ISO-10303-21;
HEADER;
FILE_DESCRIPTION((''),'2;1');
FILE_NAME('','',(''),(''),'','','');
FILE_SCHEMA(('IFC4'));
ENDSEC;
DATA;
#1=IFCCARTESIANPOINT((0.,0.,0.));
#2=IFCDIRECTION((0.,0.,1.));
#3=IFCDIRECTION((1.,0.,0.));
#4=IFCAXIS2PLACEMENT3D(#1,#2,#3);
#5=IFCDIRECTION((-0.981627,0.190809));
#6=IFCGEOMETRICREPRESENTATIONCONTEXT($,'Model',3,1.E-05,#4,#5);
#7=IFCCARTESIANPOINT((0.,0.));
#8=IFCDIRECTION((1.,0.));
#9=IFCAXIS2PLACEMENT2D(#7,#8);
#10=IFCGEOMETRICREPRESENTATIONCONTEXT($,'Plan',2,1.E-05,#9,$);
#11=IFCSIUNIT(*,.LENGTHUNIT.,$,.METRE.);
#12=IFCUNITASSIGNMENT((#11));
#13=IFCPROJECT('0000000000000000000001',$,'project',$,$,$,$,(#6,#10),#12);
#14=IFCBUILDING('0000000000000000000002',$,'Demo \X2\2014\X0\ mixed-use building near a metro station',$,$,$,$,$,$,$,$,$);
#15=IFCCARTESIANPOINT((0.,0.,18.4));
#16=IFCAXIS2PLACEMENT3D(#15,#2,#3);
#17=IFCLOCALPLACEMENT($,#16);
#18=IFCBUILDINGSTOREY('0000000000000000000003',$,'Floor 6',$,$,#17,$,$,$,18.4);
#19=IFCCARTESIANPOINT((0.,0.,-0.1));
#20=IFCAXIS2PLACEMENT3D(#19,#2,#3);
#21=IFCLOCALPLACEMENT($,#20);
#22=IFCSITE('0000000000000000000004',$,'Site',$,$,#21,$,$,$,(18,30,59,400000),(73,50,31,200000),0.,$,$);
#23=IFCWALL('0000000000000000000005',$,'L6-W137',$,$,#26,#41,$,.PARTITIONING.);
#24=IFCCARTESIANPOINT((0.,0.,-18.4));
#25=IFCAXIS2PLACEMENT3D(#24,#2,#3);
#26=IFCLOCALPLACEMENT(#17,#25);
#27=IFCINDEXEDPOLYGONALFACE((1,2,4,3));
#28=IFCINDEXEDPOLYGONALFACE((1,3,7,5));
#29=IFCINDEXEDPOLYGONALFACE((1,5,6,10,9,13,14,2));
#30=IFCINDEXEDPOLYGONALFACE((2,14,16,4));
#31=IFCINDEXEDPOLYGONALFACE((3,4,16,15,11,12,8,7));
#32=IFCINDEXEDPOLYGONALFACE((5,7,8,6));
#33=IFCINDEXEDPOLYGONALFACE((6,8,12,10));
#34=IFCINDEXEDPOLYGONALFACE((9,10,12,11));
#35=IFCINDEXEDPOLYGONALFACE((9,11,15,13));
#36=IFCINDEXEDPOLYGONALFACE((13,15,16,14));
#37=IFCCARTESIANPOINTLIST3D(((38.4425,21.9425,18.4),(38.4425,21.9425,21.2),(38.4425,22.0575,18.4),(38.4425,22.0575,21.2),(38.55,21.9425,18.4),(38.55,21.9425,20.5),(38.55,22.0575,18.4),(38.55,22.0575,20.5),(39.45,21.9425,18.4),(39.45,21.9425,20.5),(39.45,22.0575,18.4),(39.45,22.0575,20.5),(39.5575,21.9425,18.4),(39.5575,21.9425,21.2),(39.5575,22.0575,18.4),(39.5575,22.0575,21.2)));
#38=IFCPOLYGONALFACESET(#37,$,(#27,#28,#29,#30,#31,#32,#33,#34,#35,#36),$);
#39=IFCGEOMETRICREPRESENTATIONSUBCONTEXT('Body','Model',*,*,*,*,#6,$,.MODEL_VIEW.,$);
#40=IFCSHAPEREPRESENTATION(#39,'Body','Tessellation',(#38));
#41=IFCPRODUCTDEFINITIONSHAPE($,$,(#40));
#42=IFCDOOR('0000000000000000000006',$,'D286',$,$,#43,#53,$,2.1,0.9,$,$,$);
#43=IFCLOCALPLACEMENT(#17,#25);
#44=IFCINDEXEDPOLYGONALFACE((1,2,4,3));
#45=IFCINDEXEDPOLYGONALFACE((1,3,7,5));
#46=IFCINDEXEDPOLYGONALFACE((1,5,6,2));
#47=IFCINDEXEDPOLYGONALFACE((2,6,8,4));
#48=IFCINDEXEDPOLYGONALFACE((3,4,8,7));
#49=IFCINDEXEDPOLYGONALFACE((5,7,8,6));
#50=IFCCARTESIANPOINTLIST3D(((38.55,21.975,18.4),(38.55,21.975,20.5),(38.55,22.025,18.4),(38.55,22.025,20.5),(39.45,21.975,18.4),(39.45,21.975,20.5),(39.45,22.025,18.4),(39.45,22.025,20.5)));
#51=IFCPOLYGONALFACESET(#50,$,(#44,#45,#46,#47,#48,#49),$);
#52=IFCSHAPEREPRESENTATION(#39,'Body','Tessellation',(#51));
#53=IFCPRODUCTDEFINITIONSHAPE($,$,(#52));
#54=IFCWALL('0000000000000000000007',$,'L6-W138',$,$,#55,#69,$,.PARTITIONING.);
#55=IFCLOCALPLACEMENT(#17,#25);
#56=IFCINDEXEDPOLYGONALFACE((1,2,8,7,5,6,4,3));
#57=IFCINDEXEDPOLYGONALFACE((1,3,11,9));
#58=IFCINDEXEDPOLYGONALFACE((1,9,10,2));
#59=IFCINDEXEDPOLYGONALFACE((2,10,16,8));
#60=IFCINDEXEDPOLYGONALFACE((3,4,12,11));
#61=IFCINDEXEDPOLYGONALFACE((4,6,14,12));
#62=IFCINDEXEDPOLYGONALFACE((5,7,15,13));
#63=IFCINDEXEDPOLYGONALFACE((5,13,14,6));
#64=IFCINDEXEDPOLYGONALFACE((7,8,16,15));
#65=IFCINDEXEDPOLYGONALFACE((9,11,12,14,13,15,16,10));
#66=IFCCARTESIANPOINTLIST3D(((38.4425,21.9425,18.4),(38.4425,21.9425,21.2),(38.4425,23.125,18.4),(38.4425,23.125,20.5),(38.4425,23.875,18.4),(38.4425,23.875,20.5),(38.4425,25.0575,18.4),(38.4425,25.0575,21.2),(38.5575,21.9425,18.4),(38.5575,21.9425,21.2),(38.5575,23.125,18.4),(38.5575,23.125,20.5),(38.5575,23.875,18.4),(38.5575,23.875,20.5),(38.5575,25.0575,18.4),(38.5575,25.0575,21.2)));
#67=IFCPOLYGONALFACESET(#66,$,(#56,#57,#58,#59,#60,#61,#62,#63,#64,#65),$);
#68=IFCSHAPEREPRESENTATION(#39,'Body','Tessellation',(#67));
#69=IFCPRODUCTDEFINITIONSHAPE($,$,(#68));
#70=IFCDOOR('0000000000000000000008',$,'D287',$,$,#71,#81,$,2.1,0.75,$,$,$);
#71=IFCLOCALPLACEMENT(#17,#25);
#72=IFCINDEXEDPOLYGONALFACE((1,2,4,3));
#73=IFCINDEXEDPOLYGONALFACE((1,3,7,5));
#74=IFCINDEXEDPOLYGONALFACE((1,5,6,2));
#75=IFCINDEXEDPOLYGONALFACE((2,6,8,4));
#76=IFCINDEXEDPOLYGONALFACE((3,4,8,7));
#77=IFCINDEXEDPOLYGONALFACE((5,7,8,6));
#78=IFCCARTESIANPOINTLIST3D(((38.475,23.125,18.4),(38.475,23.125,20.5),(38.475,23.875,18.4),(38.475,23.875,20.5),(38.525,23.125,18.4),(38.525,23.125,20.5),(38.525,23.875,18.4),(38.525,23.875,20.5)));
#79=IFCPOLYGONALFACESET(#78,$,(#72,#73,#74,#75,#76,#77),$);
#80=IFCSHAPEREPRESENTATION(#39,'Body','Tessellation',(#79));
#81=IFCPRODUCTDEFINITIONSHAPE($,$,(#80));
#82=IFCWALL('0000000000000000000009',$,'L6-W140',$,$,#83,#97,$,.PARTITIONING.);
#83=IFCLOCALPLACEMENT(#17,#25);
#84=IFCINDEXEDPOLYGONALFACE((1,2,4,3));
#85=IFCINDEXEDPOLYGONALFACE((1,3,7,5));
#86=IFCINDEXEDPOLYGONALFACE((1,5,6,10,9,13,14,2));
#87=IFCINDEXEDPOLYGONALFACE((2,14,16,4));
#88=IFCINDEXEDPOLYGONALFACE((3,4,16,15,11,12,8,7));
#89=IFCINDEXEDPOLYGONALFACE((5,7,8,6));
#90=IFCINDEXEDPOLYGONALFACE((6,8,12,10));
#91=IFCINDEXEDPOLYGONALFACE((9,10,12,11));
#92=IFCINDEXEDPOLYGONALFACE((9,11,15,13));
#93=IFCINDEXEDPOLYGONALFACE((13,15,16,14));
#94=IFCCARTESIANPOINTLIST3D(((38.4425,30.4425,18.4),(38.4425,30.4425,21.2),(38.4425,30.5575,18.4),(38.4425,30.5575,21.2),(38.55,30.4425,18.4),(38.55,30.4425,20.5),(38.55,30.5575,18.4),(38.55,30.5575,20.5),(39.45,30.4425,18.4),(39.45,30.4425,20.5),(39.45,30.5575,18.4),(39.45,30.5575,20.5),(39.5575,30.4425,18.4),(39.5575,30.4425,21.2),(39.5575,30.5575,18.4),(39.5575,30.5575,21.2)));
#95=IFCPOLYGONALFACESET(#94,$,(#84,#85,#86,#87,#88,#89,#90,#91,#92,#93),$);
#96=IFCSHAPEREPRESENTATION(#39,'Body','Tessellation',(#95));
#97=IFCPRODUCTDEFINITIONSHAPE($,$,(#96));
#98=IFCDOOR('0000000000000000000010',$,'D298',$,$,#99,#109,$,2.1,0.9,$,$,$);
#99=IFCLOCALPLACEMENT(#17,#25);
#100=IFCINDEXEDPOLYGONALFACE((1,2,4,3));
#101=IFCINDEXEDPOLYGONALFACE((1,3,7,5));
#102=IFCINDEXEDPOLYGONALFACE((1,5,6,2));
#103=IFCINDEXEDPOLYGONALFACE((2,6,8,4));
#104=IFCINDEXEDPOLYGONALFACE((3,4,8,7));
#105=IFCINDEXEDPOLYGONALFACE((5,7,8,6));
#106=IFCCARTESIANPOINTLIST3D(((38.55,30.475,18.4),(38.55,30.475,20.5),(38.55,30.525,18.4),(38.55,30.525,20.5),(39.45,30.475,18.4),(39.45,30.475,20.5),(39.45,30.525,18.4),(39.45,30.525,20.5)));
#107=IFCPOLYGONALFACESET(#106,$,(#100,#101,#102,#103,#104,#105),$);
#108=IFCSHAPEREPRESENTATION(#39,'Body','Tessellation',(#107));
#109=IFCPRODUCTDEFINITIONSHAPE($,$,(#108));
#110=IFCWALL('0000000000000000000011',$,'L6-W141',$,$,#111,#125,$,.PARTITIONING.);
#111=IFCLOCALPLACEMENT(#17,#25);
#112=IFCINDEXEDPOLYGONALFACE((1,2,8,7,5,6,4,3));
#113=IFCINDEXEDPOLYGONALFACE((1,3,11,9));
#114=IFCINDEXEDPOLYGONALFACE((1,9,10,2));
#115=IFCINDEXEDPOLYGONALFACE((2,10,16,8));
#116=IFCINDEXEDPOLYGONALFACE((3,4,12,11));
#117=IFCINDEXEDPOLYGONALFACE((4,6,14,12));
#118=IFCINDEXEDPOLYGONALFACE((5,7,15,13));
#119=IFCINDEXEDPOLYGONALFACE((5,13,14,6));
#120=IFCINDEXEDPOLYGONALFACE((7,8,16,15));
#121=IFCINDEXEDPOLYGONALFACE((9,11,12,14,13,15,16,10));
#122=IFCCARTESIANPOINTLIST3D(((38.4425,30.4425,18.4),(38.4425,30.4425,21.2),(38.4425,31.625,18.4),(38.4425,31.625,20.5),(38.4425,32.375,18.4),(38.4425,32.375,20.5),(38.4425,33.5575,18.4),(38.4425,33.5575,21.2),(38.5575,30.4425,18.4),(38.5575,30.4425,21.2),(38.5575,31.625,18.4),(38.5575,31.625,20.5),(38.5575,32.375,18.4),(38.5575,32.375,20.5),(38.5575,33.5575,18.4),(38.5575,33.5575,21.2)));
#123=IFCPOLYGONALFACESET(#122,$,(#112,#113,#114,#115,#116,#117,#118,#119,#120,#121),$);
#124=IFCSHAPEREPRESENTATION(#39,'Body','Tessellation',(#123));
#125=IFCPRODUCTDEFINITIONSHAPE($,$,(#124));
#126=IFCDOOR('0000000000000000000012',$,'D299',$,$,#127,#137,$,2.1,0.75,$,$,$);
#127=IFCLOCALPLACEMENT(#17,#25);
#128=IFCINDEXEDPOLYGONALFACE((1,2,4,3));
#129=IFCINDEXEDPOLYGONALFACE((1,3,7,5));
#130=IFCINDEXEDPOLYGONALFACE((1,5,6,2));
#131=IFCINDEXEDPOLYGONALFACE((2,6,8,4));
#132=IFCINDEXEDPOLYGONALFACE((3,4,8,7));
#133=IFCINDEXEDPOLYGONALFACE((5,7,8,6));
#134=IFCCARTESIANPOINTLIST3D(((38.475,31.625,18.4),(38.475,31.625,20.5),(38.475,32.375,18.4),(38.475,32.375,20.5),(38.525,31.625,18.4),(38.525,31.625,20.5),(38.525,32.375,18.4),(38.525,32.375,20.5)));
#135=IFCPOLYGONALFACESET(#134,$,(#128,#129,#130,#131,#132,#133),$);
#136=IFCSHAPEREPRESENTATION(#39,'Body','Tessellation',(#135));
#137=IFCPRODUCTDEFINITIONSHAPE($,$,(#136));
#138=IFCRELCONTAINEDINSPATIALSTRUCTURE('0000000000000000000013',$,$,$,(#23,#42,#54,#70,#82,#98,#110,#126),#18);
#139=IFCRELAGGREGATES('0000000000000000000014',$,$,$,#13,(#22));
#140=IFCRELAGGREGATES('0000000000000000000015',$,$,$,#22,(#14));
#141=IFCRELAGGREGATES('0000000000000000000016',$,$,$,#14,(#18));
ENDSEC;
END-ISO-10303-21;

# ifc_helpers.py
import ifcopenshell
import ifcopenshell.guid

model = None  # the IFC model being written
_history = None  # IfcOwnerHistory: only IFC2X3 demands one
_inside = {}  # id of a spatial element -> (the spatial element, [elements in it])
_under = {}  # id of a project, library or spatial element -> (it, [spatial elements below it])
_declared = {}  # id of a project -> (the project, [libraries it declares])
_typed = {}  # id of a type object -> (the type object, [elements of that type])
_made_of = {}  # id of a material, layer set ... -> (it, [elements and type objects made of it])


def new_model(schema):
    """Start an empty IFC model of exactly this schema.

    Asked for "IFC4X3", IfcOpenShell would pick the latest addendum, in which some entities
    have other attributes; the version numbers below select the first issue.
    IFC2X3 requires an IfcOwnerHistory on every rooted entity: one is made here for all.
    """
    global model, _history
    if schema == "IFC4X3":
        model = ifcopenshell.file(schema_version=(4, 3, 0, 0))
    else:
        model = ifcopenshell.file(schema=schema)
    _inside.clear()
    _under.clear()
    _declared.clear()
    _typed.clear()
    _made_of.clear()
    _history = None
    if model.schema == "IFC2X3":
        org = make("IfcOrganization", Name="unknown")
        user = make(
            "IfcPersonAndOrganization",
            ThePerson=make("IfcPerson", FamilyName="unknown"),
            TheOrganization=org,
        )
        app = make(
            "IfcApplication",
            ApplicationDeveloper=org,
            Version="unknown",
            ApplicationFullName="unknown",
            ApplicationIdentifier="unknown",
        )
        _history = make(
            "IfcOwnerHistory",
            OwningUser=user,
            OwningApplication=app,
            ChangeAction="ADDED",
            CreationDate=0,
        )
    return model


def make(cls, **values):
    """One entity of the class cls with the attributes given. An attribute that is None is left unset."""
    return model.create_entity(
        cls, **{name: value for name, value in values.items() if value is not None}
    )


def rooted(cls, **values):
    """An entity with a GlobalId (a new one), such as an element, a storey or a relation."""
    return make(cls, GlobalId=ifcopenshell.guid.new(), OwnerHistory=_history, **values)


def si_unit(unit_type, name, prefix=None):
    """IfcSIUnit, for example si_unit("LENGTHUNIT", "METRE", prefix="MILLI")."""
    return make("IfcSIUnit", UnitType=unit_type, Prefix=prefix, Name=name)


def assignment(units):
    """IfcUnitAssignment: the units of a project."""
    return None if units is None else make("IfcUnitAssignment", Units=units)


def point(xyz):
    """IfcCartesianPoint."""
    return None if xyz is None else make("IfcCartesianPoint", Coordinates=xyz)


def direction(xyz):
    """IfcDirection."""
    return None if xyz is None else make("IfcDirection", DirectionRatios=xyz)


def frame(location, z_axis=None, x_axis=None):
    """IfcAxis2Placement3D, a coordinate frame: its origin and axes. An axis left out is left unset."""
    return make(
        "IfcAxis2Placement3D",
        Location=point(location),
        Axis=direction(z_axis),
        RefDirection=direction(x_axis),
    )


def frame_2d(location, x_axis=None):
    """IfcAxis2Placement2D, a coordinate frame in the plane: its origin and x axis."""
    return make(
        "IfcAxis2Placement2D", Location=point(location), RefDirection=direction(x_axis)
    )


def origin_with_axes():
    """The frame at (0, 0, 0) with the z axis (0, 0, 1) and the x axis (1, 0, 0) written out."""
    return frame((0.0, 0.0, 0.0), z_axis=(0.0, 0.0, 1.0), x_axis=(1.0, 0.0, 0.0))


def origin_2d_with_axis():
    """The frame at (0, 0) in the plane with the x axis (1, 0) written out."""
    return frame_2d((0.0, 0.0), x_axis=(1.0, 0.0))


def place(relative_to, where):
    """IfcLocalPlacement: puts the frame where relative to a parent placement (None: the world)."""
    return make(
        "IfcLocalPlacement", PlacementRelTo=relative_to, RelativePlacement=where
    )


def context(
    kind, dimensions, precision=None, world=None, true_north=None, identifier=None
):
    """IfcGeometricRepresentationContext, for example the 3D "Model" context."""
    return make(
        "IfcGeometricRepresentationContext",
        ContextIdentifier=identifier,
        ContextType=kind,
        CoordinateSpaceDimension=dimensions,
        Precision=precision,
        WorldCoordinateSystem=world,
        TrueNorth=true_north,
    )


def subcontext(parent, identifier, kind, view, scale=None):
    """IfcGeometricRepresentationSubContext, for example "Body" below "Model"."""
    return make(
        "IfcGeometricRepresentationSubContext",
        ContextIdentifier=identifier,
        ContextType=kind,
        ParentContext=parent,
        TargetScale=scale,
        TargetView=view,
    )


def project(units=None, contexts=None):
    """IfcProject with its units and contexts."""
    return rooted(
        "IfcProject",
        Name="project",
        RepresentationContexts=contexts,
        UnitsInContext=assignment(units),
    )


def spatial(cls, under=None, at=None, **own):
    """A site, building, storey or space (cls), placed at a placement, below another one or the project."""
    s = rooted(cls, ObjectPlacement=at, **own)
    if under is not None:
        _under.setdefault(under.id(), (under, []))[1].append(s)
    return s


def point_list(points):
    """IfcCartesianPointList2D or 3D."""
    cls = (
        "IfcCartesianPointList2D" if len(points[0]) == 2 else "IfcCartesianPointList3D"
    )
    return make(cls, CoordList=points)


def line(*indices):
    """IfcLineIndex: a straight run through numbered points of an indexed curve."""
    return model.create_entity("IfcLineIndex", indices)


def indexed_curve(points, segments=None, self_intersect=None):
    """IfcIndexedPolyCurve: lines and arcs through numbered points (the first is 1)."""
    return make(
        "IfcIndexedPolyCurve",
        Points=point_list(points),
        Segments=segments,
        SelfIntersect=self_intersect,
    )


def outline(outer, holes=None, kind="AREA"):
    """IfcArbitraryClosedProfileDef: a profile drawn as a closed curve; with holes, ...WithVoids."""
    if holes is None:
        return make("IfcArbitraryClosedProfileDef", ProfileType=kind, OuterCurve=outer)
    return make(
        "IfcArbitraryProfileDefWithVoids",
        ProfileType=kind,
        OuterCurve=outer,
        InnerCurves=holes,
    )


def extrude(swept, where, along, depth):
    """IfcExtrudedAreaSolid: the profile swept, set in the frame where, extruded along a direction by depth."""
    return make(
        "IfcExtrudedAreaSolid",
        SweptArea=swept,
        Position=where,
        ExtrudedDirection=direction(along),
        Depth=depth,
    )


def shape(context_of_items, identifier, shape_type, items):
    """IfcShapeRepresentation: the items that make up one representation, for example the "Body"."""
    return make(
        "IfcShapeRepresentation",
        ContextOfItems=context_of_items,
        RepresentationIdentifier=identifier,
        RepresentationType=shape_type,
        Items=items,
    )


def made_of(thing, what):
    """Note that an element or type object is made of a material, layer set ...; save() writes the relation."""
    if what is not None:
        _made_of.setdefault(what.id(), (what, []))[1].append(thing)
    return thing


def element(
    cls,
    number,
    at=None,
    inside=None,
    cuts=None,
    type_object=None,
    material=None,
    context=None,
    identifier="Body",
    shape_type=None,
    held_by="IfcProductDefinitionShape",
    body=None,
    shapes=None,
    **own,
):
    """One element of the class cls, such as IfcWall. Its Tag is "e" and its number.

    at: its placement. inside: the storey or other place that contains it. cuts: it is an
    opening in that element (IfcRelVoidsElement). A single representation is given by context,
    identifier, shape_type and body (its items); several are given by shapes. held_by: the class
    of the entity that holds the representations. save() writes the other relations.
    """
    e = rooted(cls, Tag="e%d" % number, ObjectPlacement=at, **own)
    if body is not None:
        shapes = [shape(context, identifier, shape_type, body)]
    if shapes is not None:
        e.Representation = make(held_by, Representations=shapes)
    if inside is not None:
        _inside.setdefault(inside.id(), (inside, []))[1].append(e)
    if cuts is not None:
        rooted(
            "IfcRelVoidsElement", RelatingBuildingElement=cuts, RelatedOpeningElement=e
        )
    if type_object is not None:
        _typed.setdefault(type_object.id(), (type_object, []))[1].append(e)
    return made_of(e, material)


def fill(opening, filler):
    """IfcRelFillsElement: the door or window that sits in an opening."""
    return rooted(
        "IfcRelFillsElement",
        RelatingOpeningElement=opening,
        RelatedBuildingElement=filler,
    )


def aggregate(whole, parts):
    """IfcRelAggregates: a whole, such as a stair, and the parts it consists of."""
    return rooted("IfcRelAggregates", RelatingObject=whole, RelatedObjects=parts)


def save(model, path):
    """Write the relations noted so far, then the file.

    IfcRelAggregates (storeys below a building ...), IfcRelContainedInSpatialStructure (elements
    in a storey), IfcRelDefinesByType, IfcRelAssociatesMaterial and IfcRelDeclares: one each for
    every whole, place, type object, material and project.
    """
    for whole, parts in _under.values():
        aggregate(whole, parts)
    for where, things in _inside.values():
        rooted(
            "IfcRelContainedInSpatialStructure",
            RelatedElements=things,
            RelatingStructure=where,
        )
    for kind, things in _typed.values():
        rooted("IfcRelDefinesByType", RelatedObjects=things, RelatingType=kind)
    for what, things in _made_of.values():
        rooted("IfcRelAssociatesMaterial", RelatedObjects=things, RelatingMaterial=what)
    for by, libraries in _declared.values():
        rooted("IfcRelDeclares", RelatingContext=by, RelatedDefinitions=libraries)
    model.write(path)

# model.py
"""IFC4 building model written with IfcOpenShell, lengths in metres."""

from ifc_helpers import new_model, si_unit, direction, frame, origin_with_axes, origin_2d_with_axis, place, context, subcontext, project, spatial, line, indexed_curve, outline, extrude, element, fill, save


model = new_model("IFC4")

# Units and contexts
model_context = context("Model", 3, precision=1e-05, world=origin_with_axes(), true_north=direction((-0.981627, 0.190809)))
plan_context = context("Plan", 2, precision=1e-05, world=origin_2d_with_axis())
body_context = subcontext(model_context, "Body", "Model", "MODEL_VIEW")
ifc_project = project(units=[si_unit("LENGTHUNIT", "METRE")], contexts=[model_context, plan_context])

# Site, building, storey
site_placement = place(None, frame((0.0, 0.0, -0.1), z_axis=(0.0, 0.0, 1.0), x_axis=(1.0, 0.0, 0.0)))
site = spatial("IfcSite", under=ifc_project, at=site_placement, Name="Site", RefLatitude=(18, 30, 59, 400000), RefLongitude=(73, 50, 31, 200000), RefElevation=0.0)
building = spatial("IfcBuilding", under=site, Name="Demo — mixed-use building near a metro station")
storey_placement = place(None, frame((0.0, 0.0, 18.4), z_axis=(0.0, 0.0, 1.0), x_axis=(1.0, 0.0, 0.0)))
storey = spatial("IfcBuildingStorey", under=building, at=storey_placement, Name="Floor 6", Elevation=18.4)

# Walls, openings, doors
wall_1_placement = place(storey_placement, frame((0.0, 0.0, -18.4), z_axis=(0.0, 0.0, 1.0), x_axis=(1.0, 0.0, 0.0)))
wall_1 = element("IfcWall", 1, at=wall_1_placement, inside=storey, Name="L6-W137", PredefinedType="PARTITIONING", context=body_context, shape_type="SweptSolid", body=[
    extrude(outline(indexed_curve([(39.5575, 21.9425), (38.4425, 21.9425), (38.4425, 22.0575), (39.5575, 22.0575)], segments=[line(1, 2, 3, 4, 1)])), frame((0.0, 0.0, 18.4), z_axis=(0.0, 0.0, 1.0), x_axis=(1.0, 0.0, 0.0)), (0.0, 0.0, 1.0), 2.8),
])
opening_1_placement = place(wall_1_placement, origin_with_axes())
opening_1 = element("IfcOpeningElement", 2, at=opening_1_placement, cuts=wall_1, context=body_context, shape_type="SweptSolid", body=[
    extrude(outline(indexed_curve([(39.45, 21.8925), (38.55, 21.8925), (38.55, 22.1075), (39.45, 22.1075)], segments=[line(1, 2, 3, 4, 1)])), frame((0.0, 0.0, 18.4), z_axis=(0.0, 0.0, 1.0), x_axis=(1.0, 0.0, 0.0)), (0.0, 0.0, 1.0), 2.1),
])
door_1_placement = place(storey_placement, frame((0.0, 0.0, -18.4), z_axis=(0.0, 0.0, 1.0), x_axis=(1.0, 0.0, 0.0)))
door_1 = element("IfcDoor", 3, at=door_1_placement, inside=storey, Name="D286", OverallHeight=2.1, OverallWidth=0.9, context=body_context, shape_type="SweptSolid", body=[
    extrude(outline(indexed_curve([(39.45, 21.975), (38.55, 21.975), (38.55, 22.025), (39.45, 22.025)], segments=[line(1, 2, 3, 4, 1)])), frame((0.0, 0.0, 18.4), z_axis=(0.0, 0.0, 1.0), x_axis=(1.0, 0.0, 0.0)), (0.0, 0.0, 1.0), 2.1),
])
fill(opening_1, door_1)
wall_2_placement = place(storey_placement, frame((0.0, 0.0, -18.4), z_axis=(0.0, 0.0, 1.0), x_axis=(1.0, 0.0, 0.0)))
wall_2 = element("IfcWall", 4, at=wall_2_placement, inside=storey, Name="L6-W138", PredefinedType="PARTITIONING", context=body_context, shape_type="SweptSolid", body=[
    extrude(outline(indexed_curve([(38.5575, 25.0575), (38.5575, 21.9425), (38.4425, 21.9425), (38.4425, 25.0575)], segments=[line(1, 2, 3, 4, 1)])), frame((0.0, 0.0, 18.4), z_axis=(0.0, 0.0, 1.0), x_axis=(1.0, 0.0, 0.0)), (0.0, 0.0, 1.0), 2.8),
])
opening_2_placement = place(wall_2_placement, origin_with_axes())
opening_2 = element("IfcOpeningElement", 5, at=opening_2_placement, cuts=wall_2, context=body_context, shape_type="SweptSolid", body=[
    extrude(outline(indexed_curve([(38.6075, 23.875), (38.6075, 23.125), (38.3925, 23.125), (38.3925, 23.875)], segments=[line(1, 2, 3, 4, 1)])), frame((0.0, 0.0, 18.4), z_axis=(0.0, 0.0, 1.0), x_axis=(1.0, 0.0, 0.0)), (0.0, 0.0, 1.0), 2.1),
])
door_2_placement = place(storey_placement, frame((0.0, 0.0, -18.4), z_axis=(0.0, 0.0, 1.0), x_axis=(1.0, 0.0, 0.0)))
door_2 = element("IfcDoor", 6, at=door_2_placement, inside=storey, Name="D287", OverallHeight=2.1, OverallWidth=0.75, context=body_context, shape_type="SweptSolid", body=[
    extrude(outline(indexed_curve([(38.525, 23.875), (38.525, 23.125), (38.475, 23.125), (38.475, 23.875)], segments=[line(1, 2, 3, 4, 1)])), frame((0.0, 0.0, 18.4), z_axis=(0.0, 0.0, 1.0), x_axis=(1.0, 0.0, 0.0)), (0.0, 0.0, 1.0), 2.1),
])
fill(opening_2, door_2)

# Walls, openings, doors
wall_3_placement = place(storey_placement, frame((0.0, 0.0, -18.4), z_axis=(0.0, 0.0, 1.0), x_axis=(1.0, 0.0, 0.0)))
wall_3 = element("IfcWall", 7, at=wall_3_placement, inside=storey, Name="L6-W140", PredefinedType="PARTITIONING", context=body_context, shape_type="SweptSolid", body=[
    extrude(outline(indexed_curve([(39.5575, 30.4425), (38.4425, 30.4425), (38.4425, 30.5575), (39.5575, 30.5575)], segments=[line(1, 2, 3, 4, 1)])), frame((0.0, 0.0, 18.4), z_axis=(0.0, 0.0, 1.0), x_axis=(1.0, 0.0, 0.0)), (0.0, 0.0, 1.0), 2.8),
])
opening_3_placement = place(wall_3_placement, origin_with_axes())
opening_3 = element("IfcOpeningElement", 8, at=opening_3_placement, cuts=wall_3, context=body_context, shape_type="SweptSolid", body=[
    extrude(outline(indexed_curve([(39.45, 30.3925), (38.55, 30.3925), (38.55, 30.6075), (39.45, 30.6075)], segments=[line(1, 2, 3, 4, 1)])), frame((0.0, 0.0, 18.4), z_axis=(0.0, 0.0, 1.0), x_axis=(1.0, 0.0, 0.0)), (0.0, 0.0, 1.0), 2.1),
])
door_3_placement = place(storey_placement, frame((0.0, 0.0, -18.4), z_axis=(0.0, 0.0, 1.0), x_axis=(1.0, 0.0, 0.0)))
door_3 = element("IfcDoor", 9, at=door_3_placement, inside=storey, Name="D298", OverallHeight=2.1, OverallWidth=0.9, context=body_context, shape_type="SweptSolid", body=[
    extrude(outline(indexed_curve([(39.45, 30.475), (38.55, 30.475), (38.55, 30.525), (39.45, 30.525)], segments=[line(1, 2, 3, 4, 1)])), frame((0.0, 0.0, 18.4), z_axis=(0.0, 0.0, 1.0), x_axis=(1.0, 0.0, 0.0)), (0.0, 0.0, 1.0), 2.1),
])
fill(opening_3, door_3)
wall_4_placement = place(storey_placement, frame((0.0, 0.0, -18.4), z_axis=(0.0, 0.0, 1.0), x_axis=(1.0, 0.0, 0.0)))
wall_4 = element("IfcWall", 10, at=wall_4_placement, inside=storey, Name="L6-W141", PredefinedType="PARTITIONING", context=body_context, shape_type="SweptSolid", body=[
    extrude(outline(indexed_curve([(38.5575, 33.5575), (38.5575, 30.4425), (38.4425, 30.4425), (38.4425, 33.5575)], segments=[line(1, 2, 3, 4, 1)])), frame((0.0, 0.0, 18.4), z_axis=(0.0, 0.0, 1.0), x_axis=(1.0, 0.0, 0.0)), (0.0, 0.0, 1.0), 2.8),
])
opening_4_placement = place(wall_4_placement, origin_with_axes())
opening_4 = element("IfcOpeningElement", 11, at=opening_4_placement, cuts=wall_4, context=body_context, shape_type="SweptSolid", body=[
    extrude(outline(indexed_curve([(38.6075, 32.375), (38.6075, 31.625), (38.3925, 31.625), (38.3925, 32.375)], segments=[line(1, 2, 3, 4, 1)])), frame((0.0, 0.0, 18.4), z_axis=(0.0, 0.0, 1.0), x_axis=(1.0, 0.0, 0.0)), (0.0, 0.0, 1.0), 2.1),
])
door_4_placement = place(storey_placement, frame((0.0, 0.0, -18.4), z_axis=(0.0, 0.0, 1.0), x_axis=(1.0, 0.0, 0.0)))
door_4 = element("IfcDoor", 12, at=door_4_placement, inside=storey, Name="D299", OverallHeight=2.1, OverallWidth=0.75, context=body_context, shape_type="SweptSolid", body=[
    extrude(outline(indexed_curve([(38.525, 32.375), (38.525, 31.625), (38.475, 31.625), (38.475, 32.375)], segments=[line(1, 2, 3, 4, 1)])), frame((0.0, 0.0, 18.4), z_axis=(0.0, 0.0, 1.0), x_axis=(1.0, 0.0, 0.0)), (0.0, 0.0, 1.0), 2.1),
])
fill(opening_4, door_4)

save(model, "model.ifc")
